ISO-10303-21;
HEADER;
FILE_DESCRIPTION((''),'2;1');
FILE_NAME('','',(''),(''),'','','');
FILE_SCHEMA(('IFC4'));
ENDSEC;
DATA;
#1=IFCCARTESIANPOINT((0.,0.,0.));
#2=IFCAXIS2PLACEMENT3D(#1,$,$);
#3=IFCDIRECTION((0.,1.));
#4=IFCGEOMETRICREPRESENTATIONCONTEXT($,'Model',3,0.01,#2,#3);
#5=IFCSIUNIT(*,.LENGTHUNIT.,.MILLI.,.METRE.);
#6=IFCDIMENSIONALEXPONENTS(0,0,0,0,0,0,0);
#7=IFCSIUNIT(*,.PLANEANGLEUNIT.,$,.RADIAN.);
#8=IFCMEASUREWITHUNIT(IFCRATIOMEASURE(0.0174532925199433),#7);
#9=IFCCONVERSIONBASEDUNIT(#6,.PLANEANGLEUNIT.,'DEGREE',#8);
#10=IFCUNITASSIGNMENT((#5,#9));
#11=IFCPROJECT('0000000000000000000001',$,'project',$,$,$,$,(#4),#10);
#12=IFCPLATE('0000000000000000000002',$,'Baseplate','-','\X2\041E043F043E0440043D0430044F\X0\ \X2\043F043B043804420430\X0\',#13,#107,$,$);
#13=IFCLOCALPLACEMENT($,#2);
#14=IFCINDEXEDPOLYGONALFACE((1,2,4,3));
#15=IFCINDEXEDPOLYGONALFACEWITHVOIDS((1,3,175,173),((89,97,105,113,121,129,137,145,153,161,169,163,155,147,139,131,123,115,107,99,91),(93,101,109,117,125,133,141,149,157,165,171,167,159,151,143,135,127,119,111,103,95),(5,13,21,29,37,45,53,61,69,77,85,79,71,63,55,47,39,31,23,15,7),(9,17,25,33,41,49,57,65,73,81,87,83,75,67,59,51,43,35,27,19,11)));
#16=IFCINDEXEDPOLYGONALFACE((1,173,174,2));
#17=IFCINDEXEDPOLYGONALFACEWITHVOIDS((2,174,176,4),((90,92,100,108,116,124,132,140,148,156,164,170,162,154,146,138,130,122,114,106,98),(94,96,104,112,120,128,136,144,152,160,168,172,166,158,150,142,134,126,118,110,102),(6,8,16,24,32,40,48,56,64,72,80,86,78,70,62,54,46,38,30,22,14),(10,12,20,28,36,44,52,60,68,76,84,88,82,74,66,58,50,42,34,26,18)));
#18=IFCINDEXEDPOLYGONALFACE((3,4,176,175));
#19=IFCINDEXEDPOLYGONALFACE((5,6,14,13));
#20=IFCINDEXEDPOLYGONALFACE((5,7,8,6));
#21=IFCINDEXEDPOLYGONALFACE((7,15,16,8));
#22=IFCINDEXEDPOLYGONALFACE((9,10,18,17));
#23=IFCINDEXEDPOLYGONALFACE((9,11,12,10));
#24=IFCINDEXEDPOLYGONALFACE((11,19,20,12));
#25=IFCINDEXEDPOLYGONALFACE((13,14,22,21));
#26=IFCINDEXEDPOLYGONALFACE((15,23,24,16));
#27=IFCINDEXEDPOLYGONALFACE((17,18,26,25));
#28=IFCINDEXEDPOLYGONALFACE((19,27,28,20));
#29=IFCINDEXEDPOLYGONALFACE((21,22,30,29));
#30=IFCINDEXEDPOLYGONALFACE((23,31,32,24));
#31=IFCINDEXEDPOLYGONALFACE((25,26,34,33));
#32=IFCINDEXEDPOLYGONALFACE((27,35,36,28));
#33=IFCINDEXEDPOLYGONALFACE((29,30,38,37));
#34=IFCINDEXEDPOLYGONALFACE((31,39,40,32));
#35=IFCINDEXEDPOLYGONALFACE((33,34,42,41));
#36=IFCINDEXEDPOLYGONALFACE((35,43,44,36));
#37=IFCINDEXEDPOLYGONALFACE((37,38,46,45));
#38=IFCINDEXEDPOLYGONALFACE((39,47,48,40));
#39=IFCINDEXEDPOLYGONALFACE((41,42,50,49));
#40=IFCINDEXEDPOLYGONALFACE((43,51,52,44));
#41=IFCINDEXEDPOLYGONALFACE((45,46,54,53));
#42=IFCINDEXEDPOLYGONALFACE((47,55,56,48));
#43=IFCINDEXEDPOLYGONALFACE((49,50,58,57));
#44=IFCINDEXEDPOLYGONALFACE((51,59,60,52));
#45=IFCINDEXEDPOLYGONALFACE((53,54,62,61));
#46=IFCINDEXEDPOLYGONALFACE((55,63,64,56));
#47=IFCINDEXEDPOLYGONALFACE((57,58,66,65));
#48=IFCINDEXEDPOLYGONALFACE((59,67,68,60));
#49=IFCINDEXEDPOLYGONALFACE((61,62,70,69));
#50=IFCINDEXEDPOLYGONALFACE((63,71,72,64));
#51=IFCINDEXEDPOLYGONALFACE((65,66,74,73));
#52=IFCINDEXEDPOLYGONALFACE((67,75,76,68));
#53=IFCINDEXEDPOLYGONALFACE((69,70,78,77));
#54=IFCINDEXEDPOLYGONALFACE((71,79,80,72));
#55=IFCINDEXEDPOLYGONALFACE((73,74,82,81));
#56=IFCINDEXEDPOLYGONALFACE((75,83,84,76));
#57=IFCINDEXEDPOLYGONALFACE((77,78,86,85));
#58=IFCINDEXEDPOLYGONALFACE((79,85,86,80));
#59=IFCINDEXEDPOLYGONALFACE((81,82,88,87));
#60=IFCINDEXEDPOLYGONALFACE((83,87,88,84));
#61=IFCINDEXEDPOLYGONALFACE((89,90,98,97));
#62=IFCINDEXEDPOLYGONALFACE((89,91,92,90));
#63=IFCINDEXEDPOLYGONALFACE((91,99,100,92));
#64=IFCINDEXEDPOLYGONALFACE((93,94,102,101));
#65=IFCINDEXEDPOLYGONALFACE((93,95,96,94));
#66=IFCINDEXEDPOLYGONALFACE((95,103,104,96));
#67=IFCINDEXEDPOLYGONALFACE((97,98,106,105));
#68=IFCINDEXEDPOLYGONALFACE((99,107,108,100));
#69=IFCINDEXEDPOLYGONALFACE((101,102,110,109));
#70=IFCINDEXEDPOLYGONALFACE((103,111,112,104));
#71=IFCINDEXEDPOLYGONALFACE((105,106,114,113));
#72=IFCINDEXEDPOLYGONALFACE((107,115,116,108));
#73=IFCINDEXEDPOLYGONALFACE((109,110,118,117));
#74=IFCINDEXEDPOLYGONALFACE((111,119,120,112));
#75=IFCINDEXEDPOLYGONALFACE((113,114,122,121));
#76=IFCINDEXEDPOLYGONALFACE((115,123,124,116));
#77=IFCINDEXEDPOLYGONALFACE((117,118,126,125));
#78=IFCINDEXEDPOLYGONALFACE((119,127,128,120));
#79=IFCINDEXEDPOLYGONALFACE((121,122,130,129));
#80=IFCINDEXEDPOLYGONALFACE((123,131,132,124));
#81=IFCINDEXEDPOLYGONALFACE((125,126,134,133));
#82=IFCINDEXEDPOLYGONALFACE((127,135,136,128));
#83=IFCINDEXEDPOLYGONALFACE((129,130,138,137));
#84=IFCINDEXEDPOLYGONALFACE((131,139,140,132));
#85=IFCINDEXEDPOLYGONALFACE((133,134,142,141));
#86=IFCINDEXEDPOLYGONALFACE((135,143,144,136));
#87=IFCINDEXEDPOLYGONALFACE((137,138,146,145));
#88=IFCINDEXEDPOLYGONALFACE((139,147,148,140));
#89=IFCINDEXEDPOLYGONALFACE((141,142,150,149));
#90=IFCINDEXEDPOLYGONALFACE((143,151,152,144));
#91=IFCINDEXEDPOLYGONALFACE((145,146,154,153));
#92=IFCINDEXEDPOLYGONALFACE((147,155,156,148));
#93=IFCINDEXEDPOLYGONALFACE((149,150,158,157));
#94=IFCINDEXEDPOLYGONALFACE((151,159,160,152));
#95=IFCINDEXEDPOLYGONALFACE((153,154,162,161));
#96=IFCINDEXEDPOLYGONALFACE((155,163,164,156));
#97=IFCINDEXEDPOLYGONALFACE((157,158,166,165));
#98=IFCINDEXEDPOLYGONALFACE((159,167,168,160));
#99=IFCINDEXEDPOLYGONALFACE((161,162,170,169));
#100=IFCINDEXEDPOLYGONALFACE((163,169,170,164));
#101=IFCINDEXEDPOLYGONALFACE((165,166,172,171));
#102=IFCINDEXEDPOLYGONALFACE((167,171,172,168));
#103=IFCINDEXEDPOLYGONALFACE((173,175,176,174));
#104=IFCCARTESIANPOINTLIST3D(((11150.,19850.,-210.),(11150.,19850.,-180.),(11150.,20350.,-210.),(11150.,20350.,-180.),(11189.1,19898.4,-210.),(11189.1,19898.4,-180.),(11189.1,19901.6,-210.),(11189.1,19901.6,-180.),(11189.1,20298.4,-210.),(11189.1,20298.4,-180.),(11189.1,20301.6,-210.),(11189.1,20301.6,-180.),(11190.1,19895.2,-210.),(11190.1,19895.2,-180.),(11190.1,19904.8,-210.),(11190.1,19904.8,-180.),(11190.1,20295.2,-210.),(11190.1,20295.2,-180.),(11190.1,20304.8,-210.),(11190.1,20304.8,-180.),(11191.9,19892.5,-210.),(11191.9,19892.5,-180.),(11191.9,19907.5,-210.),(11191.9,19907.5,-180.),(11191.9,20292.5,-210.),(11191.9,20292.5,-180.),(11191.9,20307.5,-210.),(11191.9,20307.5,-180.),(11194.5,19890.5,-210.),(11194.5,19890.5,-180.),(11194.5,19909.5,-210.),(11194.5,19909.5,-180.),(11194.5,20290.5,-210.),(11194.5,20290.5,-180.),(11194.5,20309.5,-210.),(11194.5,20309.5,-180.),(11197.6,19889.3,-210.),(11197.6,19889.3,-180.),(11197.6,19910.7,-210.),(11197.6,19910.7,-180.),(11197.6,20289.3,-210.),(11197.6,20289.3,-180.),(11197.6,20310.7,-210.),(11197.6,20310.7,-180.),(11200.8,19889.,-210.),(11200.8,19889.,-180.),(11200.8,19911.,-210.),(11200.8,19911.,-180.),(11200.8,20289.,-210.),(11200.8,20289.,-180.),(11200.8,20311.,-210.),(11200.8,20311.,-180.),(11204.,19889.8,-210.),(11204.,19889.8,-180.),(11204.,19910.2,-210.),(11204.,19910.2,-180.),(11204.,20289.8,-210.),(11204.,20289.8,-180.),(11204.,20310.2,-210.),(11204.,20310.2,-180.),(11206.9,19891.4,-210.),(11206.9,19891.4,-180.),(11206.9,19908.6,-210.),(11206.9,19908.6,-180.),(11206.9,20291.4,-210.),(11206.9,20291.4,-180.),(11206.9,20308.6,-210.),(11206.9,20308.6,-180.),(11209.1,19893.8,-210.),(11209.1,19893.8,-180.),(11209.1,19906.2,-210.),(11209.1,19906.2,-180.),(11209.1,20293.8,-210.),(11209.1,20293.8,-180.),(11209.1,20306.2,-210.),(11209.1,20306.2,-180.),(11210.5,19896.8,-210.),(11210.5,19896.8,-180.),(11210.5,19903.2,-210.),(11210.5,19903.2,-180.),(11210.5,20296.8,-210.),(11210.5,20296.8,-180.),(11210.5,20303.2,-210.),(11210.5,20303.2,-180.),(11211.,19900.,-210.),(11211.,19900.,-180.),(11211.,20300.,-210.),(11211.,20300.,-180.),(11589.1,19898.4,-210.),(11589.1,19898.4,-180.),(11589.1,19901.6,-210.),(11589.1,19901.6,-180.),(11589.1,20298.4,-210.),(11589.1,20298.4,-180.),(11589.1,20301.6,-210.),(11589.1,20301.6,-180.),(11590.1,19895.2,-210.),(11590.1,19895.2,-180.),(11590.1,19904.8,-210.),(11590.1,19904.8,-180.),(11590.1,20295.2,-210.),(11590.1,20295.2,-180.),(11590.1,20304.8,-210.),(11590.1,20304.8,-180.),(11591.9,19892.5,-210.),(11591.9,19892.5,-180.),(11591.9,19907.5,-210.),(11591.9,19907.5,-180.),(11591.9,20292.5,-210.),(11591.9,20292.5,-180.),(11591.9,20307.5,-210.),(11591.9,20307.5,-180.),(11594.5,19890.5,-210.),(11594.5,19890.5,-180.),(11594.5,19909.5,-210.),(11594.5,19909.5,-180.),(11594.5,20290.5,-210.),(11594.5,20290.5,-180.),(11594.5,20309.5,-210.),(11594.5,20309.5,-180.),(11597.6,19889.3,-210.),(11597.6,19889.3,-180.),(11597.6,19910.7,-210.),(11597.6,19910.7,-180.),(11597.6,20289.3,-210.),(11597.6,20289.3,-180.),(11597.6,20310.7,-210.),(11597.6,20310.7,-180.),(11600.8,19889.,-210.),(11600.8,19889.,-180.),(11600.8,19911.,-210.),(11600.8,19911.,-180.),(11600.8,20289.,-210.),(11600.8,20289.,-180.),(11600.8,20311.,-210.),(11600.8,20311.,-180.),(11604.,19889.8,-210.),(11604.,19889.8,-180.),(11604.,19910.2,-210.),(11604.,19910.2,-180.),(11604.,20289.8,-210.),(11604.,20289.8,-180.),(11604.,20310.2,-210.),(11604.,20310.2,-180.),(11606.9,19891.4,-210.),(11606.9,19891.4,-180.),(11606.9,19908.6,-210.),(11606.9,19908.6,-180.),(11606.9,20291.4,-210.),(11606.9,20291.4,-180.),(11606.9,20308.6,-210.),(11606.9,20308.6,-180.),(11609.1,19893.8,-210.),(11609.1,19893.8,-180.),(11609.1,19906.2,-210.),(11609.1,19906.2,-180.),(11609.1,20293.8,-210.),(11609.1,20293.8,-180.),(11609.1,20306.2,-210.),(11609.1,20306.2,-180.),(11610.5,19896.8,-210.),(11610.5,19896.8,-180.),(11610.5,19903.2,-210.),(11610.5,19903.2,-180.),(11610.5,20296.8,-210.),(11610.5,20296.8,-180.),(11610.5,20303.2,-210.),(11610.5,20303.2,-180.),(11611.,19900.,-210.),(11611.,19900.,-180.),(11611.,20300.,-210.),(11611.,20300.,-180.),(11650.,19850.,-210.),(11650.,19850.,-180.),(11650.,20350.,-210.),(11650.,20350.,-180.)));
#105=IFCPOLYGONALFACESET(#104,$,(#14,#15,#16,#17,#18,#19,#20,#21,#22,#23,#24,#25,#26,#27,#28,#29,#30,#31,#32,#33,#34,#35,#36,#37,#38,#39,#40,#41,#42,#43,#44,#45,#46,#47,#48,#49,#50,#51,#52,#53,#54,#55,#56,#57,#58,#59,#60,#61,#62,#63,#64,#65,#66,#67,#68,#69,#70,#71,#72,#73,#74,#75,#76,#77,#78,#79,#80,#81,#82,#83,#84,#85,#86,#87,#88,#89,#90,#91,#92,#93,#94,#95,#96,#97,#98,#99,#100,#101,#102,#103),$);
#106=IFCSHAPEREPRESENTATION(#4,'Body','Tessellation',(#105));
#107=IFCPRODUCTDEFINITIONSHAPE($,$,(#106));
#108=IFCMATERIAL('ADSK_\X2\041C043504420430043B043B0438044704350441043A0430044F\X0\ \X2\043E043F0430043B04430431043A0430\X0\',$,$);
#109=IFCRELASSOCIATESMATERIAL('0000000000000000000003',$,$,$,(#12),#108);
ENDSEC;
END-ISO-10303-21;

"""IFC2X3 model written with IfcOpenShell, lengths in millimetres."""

from ifc_helpers import new_model, entity, si_unit, converted_unit, direction, frame, frame_2d, origin, origin_with_axes, place, context, project, polyline, circle, outline, extrude, material, element, save


model = new_model("IFC2X3")

# Units and contexts
model_context = context("Model", 3, precision=0.01, world=origin(), true_north=direction((0.0, 1.0)))
ifc_project = project(units=[si_unit("LENGTHUNIT", "METRE", prefix="MILLI"), converted_unit("PLANEANGLEUNIT", "DEGREE", entity("IfcRatioMeasure", 0.0174532925199433), si_unit("PLANEANGLEUNIT", "RADIAN"), dimensions=[0, 0, 0, 0, 0, 0, 0])], contexts=[model_context])

# Plate, openings
ifc_material = material(Name="ADSK_Металлическая опалубка")
plate_placement = place(None, frame((11150.0, 20350.0, -180.0), z_axis=(0.0, 0.0, -1.0), x_axis=(1.0, 0.0, 0.0)))
plate = element("IfcPlate", 1, at=plate_placement, material=ifc_material, Name="Baseplate", Description="-", ObjectType="Опорная плита", context=model_context, shape_type="SweptSolid", body=[
    extrude(outline(polyline([(0.0, 0.0), (500.0, 0.0), (500.0, 500.0), (0.0, 500.0), (0.0, 0.0)])), origin_with_axes(), (0.0, 0.0, 1.0), 30.0),
])
opening_1_placement = place(plate_placement, frame((250.0, 250.0, 30.5), z_axis=(0.0, 0.0, -1.0), x_axis=(1.0, 0.0, 0.0)))
element("IfcOpeningElement", 2, at=opening_1_placement, cuts=plate, ObjectType="Opening", context=model_context, shape_type="SweptSolid", body=[
    extrude(circle(Radius=11.0, at=frame_2d((200.0, 200.0), x_axis=(1.0, 0.0))), origin(), (0.0, 0.0, 1.0), 31.0),
])
opening_2_placement = place(plate_placement, frame((250.0, 250.0, 30.5), z_axis=(0.0, 0.0, -1.0), x_axis=(1.0, 0.0, 0.0)))
element("IfcOpeningElement", 3, at=opening_2_placement, cuts=plate, ObjectType="Opening", context=model_context, shape_type="SweptSolid", body=[
    extrude(circle(Radius=11.0, at=frame_2d((-200.0, 200.0), x_axis=(1.0, 0.0))), origin(), (0.0, 0.0, 1.0), 31.0),
])
opening_3_placement = place(plate_placement, frame((250.0, 250.0, 30.5), z_axis=(0.0, 0.0, -1.0), x_axis=(1.0, 0.0, 0.0)))
element("IfcOpeningElement", 4, at=opening_3_placement, cuts=plate, ObjectType="Opening", context=model_context, shape_type="SweptSolid", body=[
    extrude(circle(Radius=11.0, at=frame_2d((200.0, -200.0), x_axis=(1.0, 0.0))), origin(), (0.0, 0.0, 1.0), 31.0),
])
opening_4_placement = place(plate_placement, frame((250.0, 250.0, 30.5), z_axis=(0.0, 0.0, -1.0), x_axis=(1.0, 0.0, 0.0)))
element("IfcOpeningElement", 5, at=opening_4_placement, cuts=plate, ObjectType="Opening", context=model_context, shape_type="SweptSolid", body=[
    extrude(circle(Radius=11.0, at=frame_2d((-200.0, -200.0), x_axis=(1.0, 0.0))), origin(), (0.0, 0.0, 1.0), 31.0),
])

save(model, "model.ifc")
